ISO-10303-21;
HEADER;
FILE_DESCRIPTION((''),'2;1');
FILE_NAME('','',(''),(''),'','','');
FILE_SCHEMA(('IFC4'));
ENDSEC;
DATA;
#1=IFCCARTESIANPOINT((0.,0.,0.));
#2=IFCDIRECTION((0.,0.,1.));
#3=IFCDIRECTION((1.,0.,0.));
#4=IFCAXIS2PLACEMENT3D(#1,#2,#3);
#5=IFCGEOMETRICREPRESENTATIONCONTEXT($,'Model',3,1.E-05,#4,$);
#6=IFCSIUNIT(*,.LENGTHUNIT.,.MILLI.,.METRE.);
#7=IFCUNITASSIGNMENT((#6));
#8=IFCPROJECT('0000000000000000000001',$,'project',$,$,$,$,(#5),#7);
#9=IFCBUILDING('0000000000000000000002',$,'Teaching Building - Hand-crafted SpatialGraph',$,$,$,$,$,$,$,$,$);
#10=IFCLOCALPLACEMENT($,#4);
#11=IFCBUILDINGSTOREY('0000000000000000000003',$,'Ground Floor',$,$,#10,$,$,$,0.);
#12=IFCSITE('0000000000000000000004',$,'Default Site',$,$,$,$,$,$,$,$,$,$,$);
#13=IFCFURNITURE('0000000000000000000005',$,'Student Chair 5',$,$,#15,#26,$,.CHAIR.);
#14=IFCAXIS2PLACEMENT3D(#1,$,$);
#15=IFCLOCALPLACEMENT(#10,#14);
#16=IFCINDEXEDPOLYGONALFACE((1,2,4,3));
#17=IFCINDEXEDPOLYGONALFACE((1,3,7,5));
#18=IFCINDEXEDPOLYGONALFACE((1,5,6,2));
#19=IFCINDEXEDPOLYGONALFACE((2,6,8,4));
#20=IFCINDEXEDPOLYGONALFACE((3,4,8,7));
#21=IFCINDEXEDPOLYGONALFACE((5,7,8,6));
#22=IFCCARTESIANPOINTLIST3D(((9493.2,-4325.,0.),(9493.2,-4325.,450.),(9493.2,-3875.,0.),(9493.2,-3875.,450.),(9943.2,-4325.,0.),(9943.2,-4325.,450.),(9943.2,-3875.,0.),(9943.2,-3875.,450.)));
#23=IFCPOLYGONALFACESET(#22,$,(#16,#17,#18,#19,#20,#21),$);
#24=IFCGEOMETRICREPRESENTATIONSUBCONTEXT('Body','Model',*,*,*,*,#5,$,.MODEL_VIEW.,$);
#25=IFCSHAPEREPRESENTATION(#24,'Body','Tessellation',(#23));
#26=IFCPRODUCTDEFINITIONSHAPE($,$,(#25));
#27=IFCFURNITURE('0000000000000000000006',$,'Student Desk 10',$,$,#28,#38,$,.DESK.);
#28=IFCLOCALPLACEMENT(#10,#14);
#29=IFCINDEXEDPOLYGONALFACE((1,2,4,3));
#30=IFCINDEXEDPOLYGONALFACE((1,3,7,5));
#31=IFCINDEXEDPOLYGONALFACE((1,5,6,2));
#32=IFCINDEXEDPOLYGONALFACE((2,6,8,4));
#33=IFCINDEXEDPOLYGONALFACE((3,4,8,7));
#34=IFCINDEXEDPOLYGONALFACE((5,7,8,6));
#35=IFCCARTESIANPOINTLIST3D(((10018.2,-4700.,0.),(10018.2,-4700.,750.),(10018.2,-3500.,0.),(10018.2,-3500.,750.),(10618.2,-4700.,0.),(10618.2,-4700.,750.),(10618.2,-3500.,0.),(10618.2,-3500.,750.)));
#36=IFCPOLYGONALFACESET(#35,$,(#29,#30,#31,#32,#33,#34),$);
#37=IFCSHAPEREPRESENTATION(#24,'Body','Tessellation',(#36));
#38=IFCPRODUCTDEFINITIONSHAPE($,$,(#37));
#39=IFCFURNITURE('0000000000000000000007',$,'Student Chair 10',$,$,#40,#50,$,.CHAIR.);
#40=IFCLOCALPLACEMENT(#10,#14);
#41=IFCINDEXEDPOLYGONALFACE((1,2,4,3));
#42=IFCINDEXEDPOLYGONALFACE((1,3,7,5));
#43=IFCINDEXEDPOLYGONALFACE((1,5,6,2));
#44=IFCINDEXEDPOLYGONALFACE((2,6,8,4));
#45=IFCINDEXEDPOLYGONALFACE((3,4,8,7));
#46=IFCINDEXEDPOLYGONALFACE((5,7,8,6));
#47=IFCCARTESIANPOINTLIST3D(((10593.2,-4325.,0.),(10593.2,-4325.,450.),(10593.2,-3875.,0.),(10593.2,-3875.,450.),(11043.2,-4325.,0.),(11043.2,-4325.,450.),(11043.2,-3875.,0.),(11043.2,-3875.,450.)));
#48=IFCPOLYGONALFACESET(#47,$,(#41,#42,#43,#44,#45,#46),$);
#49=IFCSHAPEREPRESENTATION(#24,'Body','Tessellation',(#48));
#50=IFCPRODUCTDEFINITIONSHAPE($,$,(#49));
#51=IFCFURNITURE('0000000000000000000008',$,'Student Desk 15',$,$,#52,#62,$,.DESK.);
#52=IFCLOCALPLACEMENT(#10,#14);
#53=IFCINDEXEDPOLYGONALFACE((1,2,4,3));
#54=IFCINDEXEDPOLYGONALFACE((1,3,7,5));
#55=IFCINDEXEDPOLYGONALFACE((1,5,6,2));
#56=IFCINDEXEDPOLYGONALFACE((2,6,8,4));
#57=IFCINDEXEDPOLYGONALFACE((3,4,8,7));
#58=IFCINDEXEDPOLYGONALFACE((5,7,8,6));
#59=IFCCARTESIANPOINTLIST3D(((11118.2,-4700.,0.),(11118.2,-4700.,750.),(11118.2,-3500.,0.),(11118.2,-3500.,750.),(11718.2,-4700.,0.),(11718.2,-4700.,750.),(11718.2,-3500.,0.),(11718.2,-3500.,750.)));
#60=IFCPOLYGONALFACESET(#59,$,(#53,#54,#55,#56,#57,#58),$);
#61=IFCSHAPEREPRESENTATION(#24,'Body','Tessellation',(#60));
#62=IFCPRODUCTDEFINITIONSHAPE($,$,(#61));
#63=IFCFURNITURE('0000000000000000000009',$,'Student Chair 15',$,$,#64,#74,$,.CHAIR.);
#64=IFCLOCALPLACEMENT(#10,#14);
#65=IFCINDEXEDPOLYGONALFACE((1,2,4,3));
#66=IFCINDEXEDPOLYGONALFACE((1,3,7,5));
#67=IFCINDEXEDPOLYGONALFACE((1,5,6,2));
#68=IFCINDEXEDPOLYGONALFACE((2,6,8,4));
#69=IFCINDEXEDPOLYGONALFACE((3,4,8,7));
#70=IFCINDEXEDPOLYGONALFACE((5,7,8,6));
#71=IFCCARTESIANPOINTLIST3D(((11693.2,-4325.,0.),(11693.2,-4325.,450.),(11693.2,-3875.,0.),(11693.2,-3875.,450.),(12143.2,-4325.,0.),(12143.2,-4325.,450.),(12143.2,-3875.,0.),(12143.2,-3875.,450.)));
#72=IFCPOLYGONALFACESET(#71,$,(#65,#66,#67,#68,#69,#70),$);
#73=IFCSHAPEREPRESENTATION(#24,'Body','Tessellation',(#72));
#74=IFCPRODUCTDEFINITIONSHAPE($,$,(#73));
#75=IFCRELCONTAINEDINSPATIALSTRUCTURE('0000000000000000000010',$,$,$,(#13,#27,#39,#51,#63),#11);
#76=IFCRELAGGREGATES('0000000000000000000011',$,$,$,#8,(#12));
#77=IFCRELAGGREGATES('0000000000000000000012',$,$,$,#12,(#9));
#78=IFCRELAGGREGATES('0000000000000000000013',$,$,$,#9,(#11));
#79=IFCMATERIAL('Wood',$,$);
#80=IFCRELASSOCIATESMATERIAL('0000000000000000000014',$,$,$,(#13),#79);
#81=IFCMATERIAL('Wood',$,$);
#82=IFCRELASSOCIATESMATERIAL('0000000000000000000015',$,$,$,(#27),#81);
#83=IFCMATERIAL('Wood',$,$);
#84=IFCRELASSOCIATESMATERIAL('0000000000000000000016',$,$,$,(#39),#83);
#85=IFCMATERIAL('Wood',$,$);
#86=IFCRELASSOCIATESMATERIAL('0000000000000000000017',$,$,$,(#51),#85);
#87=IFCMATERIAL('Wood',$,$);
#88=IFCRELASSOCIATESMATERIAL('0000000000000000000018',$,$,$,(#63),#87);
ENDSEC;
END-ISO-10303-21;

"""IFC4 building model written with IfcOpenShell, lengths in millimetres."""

from ifc_helpers import new_model, si_unit, frame, origin_with_axes, origin_2d, place, context, subcontext, project, spatial, rectangle, extrude, material, element, save


model = new_model("IFC4")

# Units and contexts
model_context = context("Model", 3, precision=1e-05, world=origin_with_axes())
body_context = subcontext(model_context, "Body", "Model", "MODEL_VIEW")
ifc_project = project(units=[si_unit("LENGTHUNIT", "METRE", prefix="MILLI")], contexts=[model_context])

# Site, building, storey
site = spatial("IfcSite", under=ifc_project, Name="Default Site")
building = spatial("IfcBuilding", under=site, Name="Teaching Building - Hand-crafted SpatialGraph")
storey_placement = place(None, origin_with_axes())
storey = spatial("IfcBuildingStorey", under=building, at=storey_placement, Name="Ground Floor", Elevation=0.0)

# Furniture
ifc_material_1 = material(Name="Wood")
furniture_1_placement = place(storey_placement, frame((9718.2, -4100.0, 0.0), z_axis=(0.0, 0.0, 1.0), x_axis=(1.0, 0.0, 0.0)))
element("IfcFurniture", 1, at=furniture_1_placement, inside=storey, material=ifc_material_1, Name="Student Chair 5", PredefinedType="CHAIR", context=body_context, shape_type="SweptSolid", body=[
    extrude(rectangle(XDim=450.0, YDim=450.0, at=origin_2d()), origin_with_axes(), (0.0, 0.0, 1.0), 450.0),
])
ifc_material_2 = material(Name="Wood")
furniture_2_placement = place(storey_placement, frame((10318.2, -4100.0, 0.0), z_axis=(0.0, 0.0, 1.0), x_axis=(0.0, 1.0, 0.0)))
element("IfcFurniture", 2, at=furniture_2_placement, inside=storey, material=ifc_material_2, Name="Student Desk 10", PredefinedType="DESK", context=body_context, shape_type="SweptSolid", body=[
    extrude(rectangle(XDim=1200.0, YDim=600.0, at=origin_2d()), origin_with_axes(), (0.0, 0.0, 1.0), 750.0),
])
ifc_material_3 = material(Name="Wood")
furniture_3_placement = place(storey_placement, frame((10818.2, -4100.0, 0.0), z_axis=(0.0, 0.0, 1.0), x_axis=(1.0, 0.0, 0.0)))
element("IfcFurniture", 3, at=furniture_3_placement, inside=storey, material=ifc_material_3, Name="Student Chair 10", PredefinedType="CHAIR", context=body_context, shape_type="SweptSolid", body=[
    extrude(rectangle(XDim=450.0, YDim=450.0, at=origin_2d()), origin_with_axes(), (0.0, 0.0, 1.0), 450.0),
])
ifc_material_4 = material(Name="Wood")
furniture_4_placement = place(storey_placement, frame((11418.2, -4100.0, 0.0), z_axis=(0.0, 0.0, 1.0), x_axis=(0.0, 1.0, 0.0)))
element("IfcFurniture", 4, at=furniture_4_placement, inside=storey, material=ifc_material_4, Name="Student Desk 15", PredefinedType="DESK", context=body_context, shape_type="SweptSolid", body=[
    extrude(rectangle(XDim=1200.0, YDim=600.0, at=origin_2d()), origin_with_axes(), (0.0, 0.0, 1.0), 750.0),
])
ifc_material_5 = material(Name="Wood")
furniture_5_placement = place(storey_placement, frame((11918.2, -4100.0, 0.0), z_axis=(0.0, 0.0, 1.0), x_axis=(1.0, 0.0, 0.0)))
element("IfcFurniture", 5, at=furniture_5_placement, inside=storey, material=ifc_material_5, Name="Student Chair 15", PredefinedType="CHAIR", context=body_context, shape_type="SweptSolid", body=[
    extrude(rectangle(XDim=450.0, YDim=450.0, at=origin_2d()), origin_with_axes(), (0.0, 0.0, 1.0), 450.0),
])

save(model, "model.ifc")
